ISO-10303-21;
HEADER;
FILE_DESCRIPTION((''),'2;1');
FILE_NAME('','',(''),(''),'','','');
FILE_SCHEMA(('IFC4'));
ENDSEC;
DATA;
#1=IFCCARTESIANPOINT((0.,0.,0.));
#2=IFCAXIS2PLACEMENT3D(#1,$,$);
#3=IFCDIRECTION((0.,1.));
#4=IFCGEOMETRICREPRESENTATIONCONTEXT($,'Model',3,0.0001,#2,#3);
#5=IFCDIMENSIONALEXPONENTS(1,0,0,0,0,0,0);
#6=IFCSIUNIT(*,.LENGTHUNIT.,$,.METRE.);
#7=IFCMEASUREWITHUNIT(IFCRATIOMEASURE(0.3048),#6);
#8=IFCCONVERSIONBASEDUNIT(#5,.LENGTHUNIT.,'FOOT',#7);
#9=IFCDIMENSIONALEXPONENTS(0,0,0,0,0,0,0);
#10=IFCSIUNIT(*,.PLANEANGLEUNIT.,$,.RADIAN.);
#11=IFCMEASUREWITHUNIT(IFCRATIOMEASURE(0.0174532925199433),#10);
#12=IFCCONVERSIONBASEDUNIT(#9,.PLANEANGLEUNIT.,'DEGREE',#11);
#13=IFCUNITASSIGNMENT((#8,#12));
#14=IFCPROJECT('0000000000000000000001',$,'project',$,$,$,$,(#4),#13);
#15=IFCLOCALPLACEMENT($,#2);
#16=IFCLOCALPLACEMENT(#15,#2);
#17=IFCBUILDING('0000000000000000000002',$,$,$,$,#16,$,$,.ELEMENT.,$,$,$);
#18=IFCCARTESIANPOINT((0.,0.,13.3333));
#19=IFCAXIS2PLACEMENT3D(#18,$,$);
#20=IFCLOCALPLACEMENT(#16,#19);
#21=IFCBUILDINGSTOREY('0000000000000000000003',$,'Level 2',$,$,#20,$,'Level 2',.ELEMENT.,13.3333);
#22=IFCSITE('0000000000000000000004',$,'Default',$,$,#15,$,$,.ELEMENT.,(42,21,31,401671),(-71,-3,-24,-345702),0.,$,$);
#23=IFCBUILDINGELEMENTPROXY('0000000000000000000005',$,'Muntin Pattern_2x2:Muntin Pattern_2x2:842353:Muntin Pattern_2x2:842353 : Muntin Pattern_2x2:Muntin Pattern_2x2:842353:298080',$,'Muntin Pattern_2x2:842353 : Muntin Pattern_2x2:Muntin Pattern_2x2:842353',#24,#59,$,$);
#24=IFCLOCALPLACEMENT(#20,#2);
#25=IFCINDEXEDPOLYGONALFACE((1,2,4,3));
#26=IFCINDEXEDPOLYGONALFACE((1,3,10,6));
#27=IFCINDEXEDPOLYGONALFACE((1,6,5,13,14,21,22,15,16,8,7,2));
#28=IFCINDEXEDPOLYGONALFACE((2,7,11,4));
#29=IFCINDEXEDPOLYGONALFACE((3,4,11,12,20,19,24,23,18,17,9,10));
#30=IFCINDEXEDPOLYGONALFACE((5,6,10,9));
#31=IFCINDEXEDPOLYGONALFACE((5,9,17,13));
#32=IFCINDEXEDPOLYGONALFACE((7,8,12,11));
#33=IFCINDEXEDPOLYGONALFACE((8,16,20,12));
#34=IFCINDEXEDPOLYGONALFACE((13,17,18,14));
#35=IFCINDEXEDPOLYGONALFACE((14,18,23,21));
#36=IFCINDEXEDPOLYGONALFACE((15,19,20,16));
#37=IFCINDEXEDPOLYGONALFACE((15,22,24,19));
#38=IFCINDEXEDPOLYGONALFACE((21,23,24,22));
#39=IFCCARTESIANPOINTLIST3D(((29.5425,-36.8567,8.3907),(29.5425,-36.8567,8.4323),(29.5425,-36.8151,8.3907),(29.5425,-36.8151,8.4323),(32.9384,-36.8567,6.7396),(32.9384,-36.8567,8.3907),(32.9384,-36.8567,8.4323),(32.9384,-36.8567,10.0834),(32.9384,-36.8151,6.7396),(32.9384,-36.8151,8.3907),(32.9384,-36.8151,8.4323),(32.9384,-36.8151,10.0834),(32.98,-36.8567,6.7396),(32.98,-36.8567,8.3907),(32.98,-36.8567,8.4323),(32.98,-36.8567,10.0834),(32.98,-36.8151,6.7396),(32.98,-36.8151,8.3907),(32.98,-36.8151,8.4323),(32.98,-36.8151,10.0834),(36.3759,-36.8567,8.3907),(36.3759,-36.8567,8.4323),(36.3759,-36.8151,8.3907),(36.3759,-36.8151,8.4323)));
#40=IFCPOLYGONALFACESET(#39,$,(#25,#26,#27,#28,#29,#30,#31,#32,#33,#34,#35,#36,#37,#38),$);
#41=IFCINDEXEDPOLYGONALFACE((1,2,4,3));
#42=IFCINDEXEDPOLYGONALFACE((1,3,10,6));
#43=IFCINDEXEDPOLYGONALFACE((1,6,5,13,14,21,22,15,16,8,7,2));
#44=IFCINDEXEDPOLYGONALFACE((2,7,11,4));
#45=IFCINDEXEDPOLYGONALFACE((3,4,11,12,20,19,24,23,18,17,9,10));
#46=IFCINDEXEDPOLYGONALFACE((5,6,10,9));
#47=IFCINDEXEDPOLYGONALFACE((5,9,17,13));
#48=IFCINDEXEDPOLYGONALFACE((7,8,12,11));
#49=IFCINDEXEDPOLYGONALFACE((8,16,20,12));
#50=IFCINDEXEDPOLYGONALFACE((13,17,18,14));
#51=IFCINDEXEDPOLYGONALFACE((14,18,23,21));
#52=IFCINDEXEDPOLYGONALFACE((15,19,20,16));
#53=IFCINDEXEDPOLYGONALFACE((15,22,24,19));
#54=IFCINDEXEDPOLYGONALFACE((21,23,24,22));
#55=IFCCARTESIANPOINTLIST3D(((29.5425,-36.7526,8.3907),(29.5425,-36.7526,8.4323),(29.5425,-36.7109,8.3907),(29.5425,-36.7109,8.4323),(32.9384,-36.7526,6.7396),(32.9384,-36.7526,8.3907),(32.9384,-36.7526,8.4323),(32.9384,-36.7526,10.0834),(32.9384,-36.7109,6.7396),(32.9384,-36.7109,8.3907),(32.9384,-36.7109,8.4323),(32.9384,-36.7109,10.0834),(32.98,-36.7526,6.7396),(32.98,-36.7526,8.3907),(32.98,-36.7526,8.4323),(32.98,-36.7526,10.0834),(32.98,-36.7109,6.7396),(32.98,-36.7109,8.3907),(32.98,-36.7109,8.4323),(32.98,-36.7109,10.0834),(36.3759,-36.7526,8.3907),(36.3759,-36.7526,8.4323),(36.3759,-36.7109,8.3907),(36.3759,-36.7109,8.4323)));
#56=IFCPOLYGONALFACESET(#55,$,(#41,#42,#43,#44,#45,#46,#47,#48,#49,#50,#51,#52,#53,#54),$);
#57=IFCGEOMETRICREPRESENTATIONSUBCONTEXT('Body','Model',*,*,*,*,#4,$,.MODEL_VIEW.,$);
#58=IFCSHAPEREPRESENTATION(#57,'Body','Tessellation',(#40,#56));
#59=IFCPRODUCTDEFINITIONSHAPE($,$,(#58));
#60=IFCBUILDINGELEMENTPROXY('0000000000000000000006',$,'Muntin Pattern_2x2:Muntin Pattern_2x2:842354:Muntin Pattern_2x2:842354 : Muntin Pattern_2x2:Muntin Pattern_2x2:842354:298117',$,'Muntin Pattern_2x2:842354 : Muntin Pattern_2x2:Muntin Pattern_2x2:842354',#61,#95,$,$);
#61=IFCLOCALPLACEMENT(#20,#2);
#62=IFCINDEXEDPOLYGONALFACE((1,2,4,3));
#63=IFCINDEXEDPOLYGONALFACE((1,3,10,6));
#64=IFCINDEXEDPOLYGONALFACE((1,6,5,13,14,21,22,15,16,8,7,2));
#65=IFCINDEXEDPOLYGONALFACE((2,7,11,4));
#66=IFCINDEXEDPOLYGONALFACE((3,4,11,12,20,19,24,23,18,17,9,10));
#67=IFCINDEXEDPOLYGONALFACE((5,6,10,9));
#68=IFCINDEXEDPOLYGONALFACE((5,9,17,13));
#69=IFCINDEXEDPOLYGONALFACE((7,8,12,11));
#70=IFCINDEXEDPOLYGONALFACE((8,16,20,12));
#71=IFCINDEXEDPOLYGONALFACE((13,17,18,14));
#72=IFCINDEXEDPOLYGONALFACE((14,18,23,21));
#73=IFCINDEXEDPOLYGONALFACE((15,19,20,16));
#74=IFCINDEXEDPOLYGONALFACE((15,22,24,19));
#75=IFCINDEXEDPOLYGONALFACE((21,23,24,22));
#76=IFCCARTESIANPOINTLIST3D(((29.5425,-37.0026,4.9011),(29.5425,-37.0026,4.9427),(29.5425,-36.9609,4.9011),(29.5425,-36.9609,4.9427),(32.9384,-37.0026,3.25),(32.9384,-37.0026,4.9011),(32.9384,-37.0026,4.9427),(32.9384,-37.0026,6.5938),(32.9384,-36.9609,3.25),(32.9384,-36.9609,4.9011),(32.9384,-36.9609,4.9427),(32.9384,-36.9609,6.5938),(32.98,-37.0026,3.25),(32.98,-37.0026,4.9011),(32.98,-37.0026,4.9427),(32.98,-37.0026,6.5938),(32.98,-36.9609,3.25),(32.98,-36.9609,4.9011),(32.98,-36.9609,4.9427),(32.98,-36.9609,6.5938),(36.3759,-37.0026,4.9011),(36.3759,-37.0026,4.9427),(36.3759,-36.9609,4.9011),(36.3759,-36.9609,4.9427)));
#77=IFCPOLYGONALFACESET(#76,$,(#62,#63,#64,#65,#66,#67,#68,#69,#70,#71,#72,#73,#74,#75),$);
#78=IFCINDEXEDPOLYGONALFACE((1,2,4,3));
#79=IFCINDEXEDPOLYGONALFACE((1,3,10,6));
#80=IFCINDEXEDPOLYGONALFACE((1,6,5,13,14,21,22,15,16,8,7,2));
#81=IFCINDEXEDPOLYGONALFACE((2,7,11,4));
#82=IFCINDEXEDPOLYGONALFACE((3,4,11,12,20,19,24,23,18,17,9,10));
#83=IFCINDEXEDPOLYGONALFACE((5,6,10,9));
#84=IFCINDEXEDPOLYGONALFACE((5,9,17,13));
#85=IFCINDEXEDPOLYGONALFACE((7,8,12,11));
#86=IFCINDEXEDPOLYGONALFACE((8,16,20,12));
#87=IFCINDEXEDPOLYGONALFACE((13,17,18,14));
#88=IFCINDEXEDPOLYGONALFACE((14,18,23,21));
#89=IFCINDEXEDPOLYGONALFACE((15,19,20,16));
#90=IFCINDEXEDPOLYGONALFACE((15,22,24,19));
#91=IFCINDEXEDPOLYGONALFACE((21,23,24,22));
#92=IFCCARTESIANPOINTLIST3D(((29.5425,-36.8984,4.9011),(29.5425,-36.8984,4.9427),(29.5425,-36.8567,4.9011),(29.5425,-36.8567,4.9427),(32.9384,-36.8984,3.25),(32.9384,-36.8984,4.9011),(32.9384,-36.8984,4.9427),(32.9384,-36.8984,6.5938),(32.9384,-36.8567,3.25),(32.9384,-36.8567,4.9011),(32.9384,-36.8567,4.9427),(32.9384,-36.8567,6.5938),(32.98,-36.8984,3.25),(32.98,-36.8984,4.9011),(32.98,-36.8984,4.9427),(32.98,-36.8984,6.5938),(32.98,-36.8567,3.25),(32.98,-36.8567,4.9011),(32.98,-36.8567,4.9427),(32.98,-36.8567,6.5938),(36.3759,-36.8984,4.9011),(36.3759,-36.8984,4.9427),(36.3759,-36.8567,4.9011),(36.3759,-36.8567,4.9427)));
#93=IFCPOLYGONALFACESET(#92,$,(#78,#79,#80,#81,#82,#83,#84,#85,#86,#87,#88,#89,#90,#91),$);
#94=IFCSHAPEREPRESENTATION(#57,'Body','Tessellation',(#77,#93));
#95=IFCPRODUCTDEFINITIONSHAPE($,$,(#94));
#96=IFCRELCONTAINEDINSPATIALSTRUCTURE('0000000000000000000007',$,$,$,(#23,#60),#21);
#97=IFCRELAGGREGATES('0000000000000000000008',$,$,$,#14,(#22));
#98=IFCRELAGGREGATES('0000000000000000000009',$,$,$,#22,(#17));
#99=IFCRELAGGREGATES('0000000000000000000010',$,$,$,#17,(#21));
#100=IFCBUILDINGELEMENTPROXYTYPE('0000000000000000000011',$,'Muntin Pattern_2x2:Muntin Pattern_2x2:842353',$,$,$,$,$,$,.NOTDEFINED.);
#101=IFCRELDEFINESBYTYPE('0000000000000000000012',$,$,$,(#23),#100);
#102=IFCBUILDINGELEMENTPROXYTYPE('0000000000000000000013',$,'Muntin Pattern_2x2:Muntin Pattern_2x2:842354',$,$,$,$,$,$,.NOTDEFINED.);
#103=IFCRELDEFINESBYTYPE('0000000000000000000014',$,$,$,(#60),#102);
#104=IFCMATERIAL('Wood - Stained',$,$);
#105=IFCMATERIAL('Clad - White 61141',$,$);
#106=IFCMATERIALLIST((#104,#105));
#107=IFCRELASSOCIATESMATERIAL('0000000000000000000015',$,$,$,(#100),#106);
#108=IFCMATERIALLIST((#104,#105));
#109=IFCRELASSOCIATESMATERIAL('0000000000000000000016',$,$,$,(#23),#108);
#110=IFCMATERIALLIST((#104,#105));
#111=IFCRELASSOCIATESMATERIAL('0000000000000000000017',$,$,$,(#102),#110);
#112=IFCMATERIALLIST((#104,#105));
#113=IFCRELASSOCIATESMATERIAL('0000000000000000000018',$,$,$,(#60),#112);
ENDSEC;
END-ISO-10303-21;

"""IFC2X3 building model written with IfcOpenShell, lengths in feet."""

from ifc_helpers import new_model, entity, si_unit, converted_unit, direction, frame, origin, place, context, subcontext, project, spatial, polyline, outline, extrude, source, transform, mapped, material, material_list, type_object, type_shapes, element, save


model = new_model("IFC2X3")

# Units and contexts
model_context = context("Model", 3, precision=0.0001, world=origin(), true_north=direction((0.0, 1.0)))
body_context = subcontext(model_context, "Body", "Model", "MODEL_VIEW")
ifc_project = project(units=[converted_unit("LENGTHUNIT", "FOOT", entity("IfcRatioMeasure", 0.3048), si_unit("LENGTHUNIT", "METRE"), dimensions=[1, 0, 0, 0, 0, 0, 0]), converted_unit("PLANEANGLEUNIT", "DEGREE", entity("IfcRatioMeasure", 0.0174532925199433), si_unit("PLANEANGLEUNIT", "RADIAN"), dimensions=[0, 0, 0, 0, 0, 0, 0])], contexts=[model_context])

# Site, building, storey
site_placement = place(None, origin())
site = spatial("IfcSite", under=ifc_project, at=site_placement, Name="Default", CompositionType="ELEMENT", RefLatitude=(42, 21, 31, 401671), RefLongitude=(-71, -3, -24, -345702), RefElevation=0.0)
building_placement = place(site_placement, origin())
building = spatial("IfcBuilding", under=site, at=building_placement, CompositionType="ELEMENT")
storey_placement = place(building_placement, frame((0.0, 0.0, 13.3333)))
storey = spatial("IfcBuildingStorey", under=building, at=storey_placement, Name="Level 2", LongName="Level 2", CompositionType="ELEMENT", Elevation=13.3333)

# Building element proxies
ifc_material_1 = material(Name="Wood - Stained")
ifc_material_2 = material(Name="Clad - White 61141")
ifc_material_list_1 = material_list([ifc_material_1, ifc_material_2])
ifc_material_list_2 = material_list([ifc_material_1, ifc_material_2])
building_element_proxy_type_1 = type_object("IfcBuildingElementProxyType", Name="Muntin Pattern_2x2:Muntin Pattern_2x2:842353", PredefinedType="NOTDEFINED", material=ifc_material_list_2)
shared_shape_1 = source(origin(), body_context, "Body", "SweptSolid", [
    extrude(outline(polyline([(-0.0208, -1.6719), (0.0208, -1.6719), (0.0208, -0.0208), (3.4167, -0.0208), (3.4167, 0.0208), (0.0208, 0.0208), (0.0208, 1.6719), (-0.0208, 1.6719), (-0.0208, 0.0208), (-3.4167, 0.0208), (-3.4167, -0.0208), (-0.0208, -0.0208), (-0.0208, -1.6719)])), frame((32.9592, -36.8567, 21.7448), z_axis=(0.0, 1.0, 0.0), x_axis=(1.0, 0.0, 0.0)), (0.0, 0.0, 1.0), 0.0417),
    extrude(outline(polyline([(-0.0208, -1.6719), (0.0208, -1.6719), (0.0208, -0.0208), (3.4167, -0.0208), (3.4167, 0.0208), (0.0208, 0.0208), (0.0208, 1.6719), (-0.0208, 1.6719), (-0.0208, 0.0208), (-3.4167, 0.0208), (-3.4167, -0.0208), (-0.0208, -0.0208), (-0.0208, -1.6719)])), frame((32.9592, -36.7526, 21.7448), z_axis=(0.0, 1.0, 0.0), x_axis=(1.0, 0.0, 0.0)), (0.0, 0.0, 1.0), 0.0417),
])
type_shapes(building_element_proxy_type_1, [shared_shape_1])
proxy_1_placement = place(building_placement, origin())
element("IfcBuildingElementProxy", 1, at=proxy_1_placement, inside=storey, type_object=building_element_proxy_type_1, material=ifc_material_list_1, Name="Muntin Pattern_2x2:Muntin Pattern_2x2:842353:Muntin Pattern_2x2:842353 : Muntin Pattern_2x2:Muntin Pattern_2x2:842353:298080", ObjectType="Muntin Pattern_2x2:842353 : Muntin Pattern_2x2:Muntin Pattern_2x2:842353", context=body_context, shape_type="MappedRepresentation", body=[
    mapped(shared_shape_1, transform((0.0, 0.0, 0.0), scale=1.0)),
])
ifc_material_list_3 = material_list([ifc_material_1, ifc_material_2])
ifc_material_list_4 = material_list([ifc_material_1, ifc_material_2])
building_element_proxy_type_2 = type_object("IfcBuildingElementProxyType", Name="Muntin Pattern_2x2:Muntin Pattern_2x2:842354", PredefinedType="NOTDEFINED", material=ifc_material_list_4)
shared_shape_2 = source(origin(), body_context, "Body", "SweptSolid", [
    extrude(outline(polyline([(-0.0208, -1.6719), (0.0208, -1.6719), (0.0208, -0.0208), (3.4167, -0.0208), (3.4167, 0.0208), (0.0208, 0.0208), (0.0208, 1.6719), (-0.0208, 1.6719), (-0.0208, 0.0208), (-3.4167, 0.0208), (-3.4167, -0.0208), (-0.0208, -0.0208), (-0.0208, -1.6719)])), frame((32.9592, -37.0026, 18.2552), z_axis=(0.0, 1.0, 0.0), x_axis=(1.0, 0.0, 0.0)), (0.0, 0.0, 1.0), 0.0417),
    extrude(outline(polyline([(-0.0208, -1.6719), (0.0208, -1.6719), (0.0208, -0.0208), (3.4167, -0.0208), (3.4167, 0.0208), (0.0208, 0.0208), (0.0208, 1.6719), (-0.0208, 1.6719), (-0.0208, 0.0208), (-3.4167, 0.0208), (-3.4167, -0.0208), (-0.0208, -0.0208), (-0.0208, -1.6719)])), frame((32.9592, -36.8984, 18.2552), z_axis=(0.0, 1.0, 0.0), x_axis=(1.0, 0.0, 0.0)), (0.0, 0.0, 1.0), 0.0417),
])
type_shapes(building_element_proxy_type_2, [shared_shape_2])
proxy_2_placement = place(building_placement, origin())
element("IfcBuildingElementProxy", 2, at=proxy_2_placement, inside=storey, type_object=building_element_proxy_type_2, material=ifc_material_list_3, Name="Muntin Pattern_2x2:Muntin Pattern_2x2:842354:Muntin Pattern_2x2:842354 : Muntin Pattern_2x2:Muntin Pattern_2x2:842354:298117", ObjectType="Muntin Pattern_2x2:842354 : Muntin Pattern_2x2:Muntin Pattern_2x2:842354", context=body_context, shape_type="MappedRepresentation", body=[
    mapped(shared_shape_2, transform((0.0, 0.0, 0.0), scale=1.0)),
])

save(model, "model.ifc")
